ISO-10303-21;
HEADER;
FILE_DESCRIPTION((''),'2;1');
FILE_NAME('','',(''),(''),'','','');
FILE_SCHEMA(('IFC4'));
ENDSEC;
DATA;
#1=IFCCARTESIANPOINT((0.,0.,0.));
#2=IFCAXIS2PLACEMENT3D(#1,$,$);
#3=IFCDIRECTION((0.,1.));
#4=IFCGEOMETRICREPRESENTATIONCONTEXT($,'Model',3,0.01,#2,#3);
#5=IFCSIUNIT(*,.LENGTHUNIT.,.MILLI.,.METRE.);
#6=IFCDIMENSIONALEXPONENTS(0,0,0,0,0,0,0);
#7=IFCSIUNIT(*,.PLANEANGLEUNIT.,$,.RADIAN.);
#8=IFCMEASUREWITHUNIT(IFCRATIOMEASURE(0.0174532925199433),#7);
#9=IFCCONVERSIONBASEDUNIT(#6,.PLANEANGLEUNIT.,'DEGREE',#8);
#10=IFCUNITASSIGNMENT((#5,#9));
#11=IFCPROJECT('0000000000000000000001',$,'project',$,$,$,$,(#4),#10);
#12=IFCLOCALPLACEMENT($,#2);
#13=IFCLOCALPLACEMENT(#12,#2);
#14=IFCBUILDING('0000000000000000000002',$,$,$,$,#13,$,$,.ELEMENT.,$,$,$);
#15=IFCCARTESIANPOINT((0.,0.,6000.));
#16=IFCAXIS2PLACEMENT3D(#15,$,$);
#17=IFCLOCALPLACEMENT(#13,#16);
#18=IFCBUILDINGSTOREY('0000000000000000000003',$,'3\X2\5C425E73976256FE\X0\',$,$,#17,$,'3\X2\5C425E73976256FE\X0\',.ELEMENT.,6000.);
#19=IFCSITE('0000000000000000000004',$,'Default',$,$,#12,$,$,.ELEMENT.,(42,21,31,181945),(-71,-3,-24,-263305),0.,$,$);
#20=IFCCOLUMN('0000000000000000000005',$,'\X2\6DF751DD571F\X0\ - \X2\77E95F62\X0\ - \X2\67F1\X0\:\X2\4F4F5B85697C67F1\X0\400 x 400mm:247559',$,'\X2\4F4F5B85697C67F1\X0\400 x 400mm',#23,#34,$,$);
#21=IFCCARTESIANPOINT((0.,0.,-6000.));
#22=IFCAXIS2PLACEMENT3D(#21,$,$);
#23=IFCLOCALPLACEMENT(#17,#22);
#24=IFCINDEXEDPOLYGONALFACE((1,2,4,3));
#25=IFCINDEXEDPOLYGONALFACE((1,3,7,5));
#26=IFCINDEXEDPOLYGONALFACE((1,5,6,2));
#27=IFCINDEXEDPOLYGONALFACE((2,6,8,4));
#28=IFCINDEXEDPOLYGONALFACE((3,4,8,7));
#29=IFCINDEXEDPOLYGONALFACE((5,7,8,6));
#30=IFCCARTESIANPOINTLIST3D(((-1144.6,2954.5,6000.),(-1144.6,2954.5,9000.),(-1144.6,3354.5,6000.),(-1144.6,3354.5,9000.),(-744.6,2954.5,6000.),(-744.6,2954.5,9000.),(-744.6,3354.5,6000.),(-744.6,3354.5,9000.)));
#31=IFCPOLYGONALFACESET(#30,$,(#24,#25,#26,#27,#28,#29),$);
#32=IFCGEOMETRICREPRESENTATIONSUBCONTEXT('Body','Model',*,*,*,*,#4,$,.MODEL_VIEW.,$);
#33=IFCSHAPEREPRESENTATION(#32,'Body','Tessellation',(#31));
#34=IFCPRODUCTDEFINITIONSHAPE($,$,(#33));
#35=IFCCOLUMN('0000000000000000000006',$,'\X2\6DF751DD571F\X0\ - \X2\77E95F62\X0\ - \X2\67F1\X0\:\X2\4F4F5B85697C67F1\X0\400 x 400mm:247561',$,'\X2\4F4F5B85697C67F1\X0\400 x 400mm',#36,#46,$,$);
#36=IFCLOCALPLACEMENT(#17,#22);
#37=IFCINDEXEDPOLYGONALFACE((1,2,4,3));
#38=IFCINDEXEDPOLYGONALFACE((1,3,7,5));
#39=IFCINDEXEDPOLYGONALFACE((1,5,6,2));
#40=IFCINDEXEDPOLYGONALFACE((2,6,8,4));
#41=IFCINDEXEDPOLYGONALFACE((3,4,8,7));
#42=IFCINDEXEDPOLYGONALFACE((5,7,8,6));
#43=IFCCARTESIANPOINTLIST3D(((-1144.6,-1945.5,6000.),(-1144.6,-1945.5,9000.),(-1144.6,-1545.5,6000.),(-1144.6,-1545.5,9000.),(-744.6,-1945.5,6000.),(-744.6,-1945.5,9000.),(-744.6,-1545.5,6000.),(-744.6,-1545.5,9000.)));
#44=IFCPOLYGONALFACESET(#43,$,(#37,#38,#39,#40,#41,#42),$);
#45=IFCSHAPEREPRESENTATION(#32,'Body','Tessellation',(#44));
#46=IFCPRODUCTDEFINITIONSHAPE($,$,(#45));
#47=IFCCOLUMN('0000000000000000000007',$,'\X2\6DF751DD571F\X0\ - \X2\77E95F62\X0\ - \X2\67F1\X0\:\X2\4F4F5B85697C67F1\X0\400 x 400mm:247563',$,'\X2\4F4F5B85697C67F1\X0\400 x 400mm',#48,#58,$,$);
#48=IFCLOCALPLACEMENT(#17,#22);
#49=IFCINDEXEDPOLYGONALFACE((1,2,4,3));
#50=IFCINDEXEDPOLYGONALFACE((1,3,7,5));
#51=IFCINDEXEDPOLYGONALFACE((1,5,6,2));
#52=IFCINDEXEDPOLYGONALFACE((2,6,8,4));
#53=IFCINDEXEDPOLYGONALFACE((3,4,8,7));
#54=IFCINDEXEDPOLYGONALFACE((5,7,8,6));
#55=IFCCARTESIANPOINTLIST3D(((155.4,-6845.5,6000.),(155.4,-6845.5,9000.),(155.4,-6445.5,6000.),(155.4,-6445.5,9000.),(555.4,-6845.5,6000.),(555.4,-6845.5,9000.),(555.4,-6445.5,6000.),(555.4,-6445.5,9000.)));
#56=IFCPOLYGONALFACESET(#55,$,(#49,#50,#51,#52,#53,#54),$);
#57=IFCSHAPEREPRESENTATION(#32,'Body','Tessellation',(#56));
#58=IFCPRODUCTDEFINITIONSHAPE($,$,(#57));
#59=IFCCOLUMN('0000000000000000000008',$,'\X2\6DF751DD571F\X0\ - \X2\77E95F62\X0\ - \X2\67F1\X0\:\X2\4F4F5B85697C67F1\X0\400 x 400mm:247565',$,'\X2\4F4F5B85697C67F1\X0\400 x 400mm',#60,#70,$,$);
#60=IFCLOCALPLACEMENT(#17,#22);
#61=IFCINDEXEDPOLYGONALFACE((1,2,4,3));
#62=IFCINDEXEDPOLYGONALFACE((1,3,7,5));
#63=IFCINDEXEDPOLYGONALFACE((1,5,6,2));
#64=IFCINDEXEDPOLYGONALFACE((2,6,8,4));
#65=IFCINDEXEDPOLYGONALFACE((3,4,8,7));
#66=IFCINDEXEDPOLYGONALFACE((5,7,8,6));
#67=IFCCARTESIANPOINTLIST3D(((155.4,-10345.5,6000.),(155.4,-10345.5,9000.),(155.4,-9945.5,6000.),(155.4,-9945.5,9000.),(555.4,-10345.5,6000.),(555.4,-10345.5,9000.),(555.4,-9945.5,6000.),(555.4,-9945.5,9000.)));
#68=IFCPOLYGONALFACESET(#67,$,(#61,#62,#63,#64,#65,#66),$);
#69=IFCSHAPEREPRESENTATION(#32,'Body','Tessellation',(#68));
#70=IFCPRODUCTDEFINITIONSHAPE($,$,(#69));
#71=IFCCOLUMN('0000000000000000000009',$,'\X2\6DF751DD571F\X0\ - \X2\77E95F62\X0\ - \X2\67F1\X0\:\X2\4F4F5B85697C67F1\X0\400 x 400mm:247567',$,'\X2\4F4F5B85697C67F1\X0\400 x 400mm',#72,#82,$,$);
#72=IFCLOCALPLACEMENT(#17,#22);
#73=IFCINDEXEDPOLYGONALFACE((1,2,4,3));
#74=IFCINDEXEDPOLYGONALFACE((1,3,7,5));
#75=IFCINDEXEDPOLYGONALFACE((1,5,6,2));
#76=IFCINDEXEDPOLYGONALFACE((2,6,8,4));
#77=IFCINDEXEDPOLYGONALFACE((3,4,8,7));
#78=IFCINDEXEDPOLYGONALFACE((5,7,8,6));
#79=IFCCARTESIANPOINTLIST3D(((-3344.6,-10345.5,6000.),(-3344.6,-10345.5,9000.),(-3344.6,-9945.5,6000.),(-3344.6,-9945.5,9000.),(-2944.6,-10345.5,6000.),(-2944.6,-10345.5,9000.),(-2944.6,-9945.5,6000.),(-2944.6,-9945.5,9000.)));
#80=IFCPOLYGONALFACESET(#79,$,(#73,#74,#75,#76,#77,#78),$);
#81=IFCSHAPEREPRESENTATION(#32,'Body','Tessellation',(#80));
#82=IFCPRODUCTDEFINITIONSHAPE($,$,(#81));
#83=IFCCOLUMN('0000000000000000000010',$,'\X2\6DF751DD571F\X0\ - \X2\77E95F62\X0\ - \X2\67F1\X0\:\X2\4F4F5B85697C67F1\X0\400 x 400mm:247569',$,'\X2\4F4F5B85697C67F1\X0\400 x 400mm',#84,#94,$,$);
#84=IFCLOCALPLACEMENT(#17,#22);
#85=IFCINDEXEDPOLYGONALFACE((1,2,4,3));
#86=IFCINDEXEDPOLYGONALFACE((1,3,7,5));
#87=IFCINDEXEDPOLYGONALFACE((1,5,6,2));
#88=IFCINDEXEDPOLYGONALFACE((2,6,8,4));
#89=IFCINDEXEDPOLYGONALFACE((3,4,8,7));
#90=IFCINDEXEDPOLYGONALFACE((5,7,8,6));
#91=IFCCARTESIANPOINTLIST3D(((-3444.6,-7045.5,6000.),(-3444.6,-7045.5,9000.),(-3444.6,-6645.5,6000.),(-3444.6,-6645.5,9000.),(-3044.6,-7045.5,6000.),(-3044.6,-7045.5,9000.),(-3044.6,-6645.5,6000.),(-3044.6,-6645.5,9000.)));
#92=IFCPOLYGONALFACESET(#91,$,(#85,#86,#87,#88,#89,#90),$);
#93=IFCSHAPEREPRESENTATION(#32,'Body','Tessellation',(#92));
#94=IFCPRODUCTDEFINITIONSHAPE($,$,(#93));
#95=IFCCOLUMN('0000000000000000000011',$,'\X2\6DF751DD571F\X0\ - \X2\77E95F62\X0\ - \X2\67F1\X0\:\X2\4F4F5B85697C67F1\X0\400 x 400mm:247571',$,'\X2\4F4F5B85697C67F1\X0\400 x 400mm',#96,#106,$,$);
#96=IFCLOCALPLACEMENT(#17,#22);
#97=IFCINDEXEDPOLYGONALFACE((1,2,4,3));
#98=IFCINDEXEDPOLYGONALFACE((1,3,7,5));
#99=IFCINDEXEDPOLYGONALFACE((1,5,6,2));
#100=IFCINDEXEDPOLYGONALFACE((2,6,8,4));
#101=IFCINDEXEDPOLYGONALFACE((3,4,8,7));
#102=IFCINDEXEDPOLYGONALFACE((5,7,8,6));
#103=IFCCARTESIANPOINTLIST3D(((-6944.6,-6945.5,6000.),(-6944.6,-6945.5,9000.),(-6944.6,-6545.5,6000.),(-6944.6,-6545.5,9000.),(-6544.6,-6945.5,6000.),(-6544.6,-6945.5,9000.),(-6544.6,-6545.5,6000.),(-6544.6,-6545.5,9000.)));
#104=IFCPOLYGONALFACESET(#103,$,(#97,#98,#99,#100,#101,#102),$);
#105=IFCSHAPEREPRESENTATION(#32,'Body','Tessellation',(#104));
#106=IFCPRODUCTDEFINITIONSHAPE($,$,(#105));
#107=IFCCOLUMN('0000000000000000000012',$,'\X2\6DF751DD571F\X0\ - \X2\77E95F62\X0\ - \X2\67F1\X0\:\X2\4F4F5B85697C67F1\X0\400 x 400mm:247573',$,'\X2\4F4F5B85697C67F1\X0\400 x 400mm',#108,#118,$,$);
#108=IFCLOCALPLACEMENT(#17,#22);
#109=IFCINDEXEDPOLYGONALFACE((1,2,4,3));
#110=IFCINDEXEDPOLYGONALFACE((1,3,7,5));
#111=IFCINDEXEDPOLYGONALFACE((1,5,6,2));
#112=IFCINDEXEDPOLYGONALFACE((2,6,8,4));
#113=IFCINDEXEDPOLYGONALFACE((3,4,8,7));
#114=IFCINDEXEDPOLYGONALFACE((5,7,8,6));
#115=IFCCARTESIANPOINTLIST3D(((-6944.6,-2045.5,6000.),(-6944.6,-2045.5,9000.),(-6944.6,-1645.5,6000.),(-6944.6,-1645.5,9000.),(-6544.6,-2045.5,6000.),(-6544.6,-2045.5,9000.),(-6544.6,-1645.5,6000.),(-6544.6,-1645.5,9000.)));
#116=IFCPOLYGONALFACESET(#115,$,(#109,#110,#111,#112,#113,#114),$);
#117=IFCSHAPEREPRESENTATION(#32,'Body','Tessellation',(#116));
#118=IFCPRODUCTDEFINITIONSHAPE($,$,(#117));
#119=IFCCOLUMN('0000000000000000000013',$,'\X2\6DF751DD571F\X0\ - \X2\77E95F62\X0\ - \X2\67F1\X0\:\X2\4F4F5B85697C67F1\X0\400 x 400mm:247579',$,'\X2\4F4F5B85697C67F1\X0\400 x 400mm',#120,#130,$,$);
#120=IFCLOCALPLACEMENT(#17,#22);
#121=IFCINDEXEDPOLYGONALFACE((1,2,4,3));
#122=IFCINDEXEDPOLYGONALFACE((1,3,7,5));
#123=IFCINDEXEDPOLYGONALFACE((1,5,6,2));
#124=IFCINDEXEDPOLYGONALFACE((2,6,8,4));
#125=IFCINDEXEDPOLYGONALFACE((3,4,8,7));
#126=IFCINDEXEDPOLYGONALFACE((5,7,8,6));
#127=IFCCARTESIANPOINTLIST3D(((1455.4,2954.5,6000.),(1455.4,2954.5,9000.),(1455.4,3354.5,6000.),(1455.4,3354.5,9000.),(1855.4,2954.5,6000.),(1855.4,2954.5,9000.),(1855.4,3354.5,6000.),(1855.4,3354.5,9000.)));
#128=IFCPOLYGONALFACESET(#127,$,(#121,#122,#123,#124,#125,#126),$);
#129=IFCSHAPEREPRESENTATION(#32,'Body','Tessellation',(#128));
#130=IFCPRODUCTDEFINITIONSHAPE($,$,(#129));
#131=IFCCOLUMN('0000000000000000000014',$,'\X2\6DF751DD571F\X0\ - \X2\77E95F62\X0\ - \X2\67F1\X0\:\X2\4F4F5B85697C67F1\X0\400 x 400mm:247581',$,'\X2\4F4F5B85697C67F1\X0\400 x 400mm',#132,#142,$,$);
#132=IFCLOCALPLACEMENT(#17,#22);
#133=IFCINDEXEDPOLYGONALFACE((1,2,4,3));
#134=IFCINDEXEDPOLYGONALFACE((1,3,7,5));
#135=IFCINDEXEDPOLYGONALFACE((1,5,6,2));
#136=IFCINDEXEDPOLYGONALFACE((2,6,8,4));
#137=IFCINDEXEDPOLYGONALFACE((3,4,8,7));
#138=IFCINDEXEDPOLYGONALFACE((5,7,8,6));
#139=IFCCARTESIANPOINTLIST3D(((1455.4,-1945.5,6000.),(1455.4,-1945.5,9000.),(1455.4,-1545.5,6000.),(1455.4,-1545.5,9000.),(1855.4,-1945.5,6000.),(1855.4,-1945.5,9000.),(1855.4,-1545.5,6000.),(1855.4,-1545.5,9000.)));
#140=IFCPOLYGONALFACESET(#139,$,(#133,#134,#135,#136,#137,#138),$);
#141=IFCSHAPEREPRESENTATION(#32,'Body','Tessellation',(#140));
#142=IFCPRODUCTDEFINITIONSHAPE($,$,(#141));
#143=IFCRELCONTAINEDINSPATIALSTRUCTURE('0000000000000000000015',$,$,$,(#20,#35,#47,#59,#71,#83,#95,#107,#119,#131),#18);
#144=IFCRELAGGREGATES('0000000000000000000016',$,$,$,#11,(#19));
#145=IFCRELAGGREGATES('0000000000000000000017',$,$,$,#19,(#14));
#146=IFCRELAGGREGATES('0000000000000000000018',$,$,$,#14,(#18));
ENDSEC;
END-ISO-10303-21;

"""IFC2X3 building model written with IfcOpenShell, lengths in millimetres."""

from ifc_helpers import new_model, entity, si_unit, converted_unit, direction, frame, frame_2d, origin, origin_2d_with_axis, place, context, subcontext, project, spatial, rectangle, extrude, source, transform, mapped, element, save


model = new_model("IFC2X3")

# Units and contexts
model_context = context("Model", 3, precision=0.01, world=origin(), true_north=direction((0.0, 1.0)))
body_context = subcontext(model_context, "Body", "Model", "MODEL_VIEW")
ifc_project = project(units=[si_unit("LENGTHUNIT", "METRE", prefix="MILLI"), converted_unit("PLANEANGLEUNIT", "DEGREE", entity("IfcRatioMeasure", 0.0174532925199433), si_unit("PLANEANGLEUNIT", "RADIAN"), dimensions=[0, 0, 0, 0, 0, 0, 0])], contexts=[model_context])

# Site, building, storey
site_placement = place(None, origin())
site = spatial("IfcSite", under=ifc_project, at=site_placement, Name="Default", CompositionType="ELEMENT", RefLatitude=(42, 21, 31, 181945), RefLongitude=(-71, -3, -24, -263305), RefElevation=0.0)
building_placement = place(site_placement, origin())
building = spatial("IfcBuilding", under=site, at=building_placement, CompositionType="ELEMENT")
storey_placement = place(building_placement, frame((0.0, 0.0, 6000.0)))
storey = spatial("IfcBuildingStorey", under=building, at=storey_placement, Name="3层平面图", LongName="3层平面图", CompositionType="ELEMENT", Elevation=6000.0)

# Columns
shared_shape_1 = source(origin(), body_context, "Body", "SweptSolid", [
    extrude(rectangle(XDim=400.0, YDim=400.0, at=origin_2d_with_axis()), frame((-944.6, 3154.5, 6000.0), z_axis=(0.0, 0.0, 1.0), x_axis=(0.0, -1.0, 0.0)), (0.0, 0.0, 1.0), 3000.0),
])
column_1_placement = place(storey_placement, frame((0.0, 0.0, -6000.0)))
element("IfcColumn", 1, at=column_1_placement, inside=storey, Name="混凝土 - 矩形 - 柱:住宅楼柱400 x 400mm:247559", ObjectType="住宅楼柱400 x 400mm", context=body_context, shape_type="MappedRepresentation", body=[
    mapped(shared_shape_1, transform((0.0, 0.0, 0.0), scale=1.0)),
])
shared_shape_2 = source(origin(), body_context, "Body", "SweptSolid", [
    extrude(rectangle(XDim=400.0, YDim=400.0, at=origin_2d_with_axis()), frame((-944.6, -1745.5, 6000.0), z_axis=(0.0, 0.0, 1.0), x_axis=(0.0, -1.0, 0.0)), (0.0, 0.0, 1.0), 3000.0),
])
column_2_placement = place(storey_placement, frame((0.0, 0.0, -6000.0)))
element("IfcColumn", 2, at=column_2_placement, inside=storey, Name="混凝土 - 矩形 - 柱:住宅楼柱400 x 400mm:247561", ObjectType="住宅楼柱400 x 400mm", context=body_context, shape_type="MappedRepresentation", body=[
    mapped(shared_shape_2, transform((0.0, 0.0, 0.0), scale=1.0)),
])
shared_shape_3 = source(origin(), body_context, "Body", "SweptSolid", [
    extrude(rectangle(XDim=400.0, YDim=400.0, at=frame_2d((0.0, 0.0), x_axis=(1.0, 0.0))), frame((355.4, -6645.5, 6000.0), z_axis=(0.0, 0.0, 1.0), x_axis=(0.0, -1.0, 0.0)), (0.0, 0.0, 1.0), 3000.0),
])
column_3_placement = place(storey_placement, frame((0.0, 0.0, -6000.0)))
element("IfcColumn", 3, at=column_3_placement, inside=storey, Name="混凝土 - 矩形 - 柱:住宅楼柱400 x 400mm:247563", ObjectType="住宅楼柱400 x 400mm", context=body_context, shape_type="MappedRepresentation", body=[
    mapped(shared_shape_3, transform((0.0, 0.0, 0.0), scale=1.0)),
])
shared_shape_4 = source(origin(), body_context, "Body", "SweptSolid", [
    extrude(rectangle(XDim=400.0, YDim=400.0, at=frame_2d((0.0, 0.0), x_axis=(1.0, 0.0))), frame((355.4, -10145.5, 6000.0), z_axis=(0.0, 0.0, 1.0), x_axis=(0.0, -1.0, 0.0)), (0.0, 0.0, 1.0), 3000.0),
])
column_4_placement = place(storey_placement, frame((0.0, 0.0, -6000.0)))
element("IfcColumn", 4, at=column_4_placement, inside=storey, Name="混凝土 - 矩形 - 柱:住宅楼柱400 x 400mm:247565", ObjectType="住宅楼柱400 x 400mm", context=body_context, shape_type="MappedRepresentation", body=[
    mapped(shared_shape_4, transform((0.0, 0.0, 0.0), scale=1.0)),
])
shared_shape_5 = source(origin(), body_context, "Body", "SweptSolid", [
    extrude(rectangle(XDim=400.0, YDim=400.0, at=origin_2d_with_axis()), frame((-3144.6, -10145.5, 6000.0), z_axis=(0.0, 0.0, 1.0), x_axis=(0.0, -1.0, 0.0)), (0.0, 0.0, 1.0), 3000.0),
])
column_5_placement = place(storey_placement, frame((0.0, 0.0, -6000.0)))
element("IfcColumn", 5, at=column_5_placement, inside=storey, Name="混凝土 - 矩形 - 柱:住宅楼柱400 x 400mm:247567", ObjectType="住宅楼柱400 x 400mm", context=body_context, shape_type="MappedRepresentation", body=[
    mapped(shared_shape_5, transform((0.0, 0.0, 0.0), scale=1.0)),
])
shared_shape_6 = source(origin(), body_context, "Body", "SweptSolid", [
    extrude(rectangle(XDim=400.0, YDim=400.0, at=origin_2d_with_axis()), frame((-3244.6, -6845.5, 6000.0), z_axis=(0.0, 0.0, 1.0), x_axis=(0.0, -1.0, 0.0)), (0.0, 0.0, 1.0), 3000.0),
])
column_6_placement = place(storey_placement, frame((0.0, 0.0, -6000.0)))
element("IfcColumn", 6, at=column_6_placement, inside=storey, Name="混凝土 - 矩形 - 柱:住宅楼柱400 x 400mm:247569", ObjectType="住宅楼柱400 x 400mm", context=body_context, shape_type="MappedRepresentation", body=[
    mapped(shared_shape_6, transform((0.0, 0.0, 0.0), scale=1.0)),
])
shared_shape_7 = source(origin(), body_context, "Body", "SweptSolid", [
    extrude(rectangle(XDim=400.0, YDim=400.0, at=origin_2d_with_axis()), frame((-6744.6, -6745.5, 6000.0), z_axis=(0.0, 0.0, 1.0), x_axis=(0.0, -1.0, 0.0)), (0.0, 0.0, 1.0), 3000.0),
])
column_7_placement = place(storey_placement, frame((0.0, 0.0, -6000.0)))
element("IfcColumn", 7, at=column_7_placement, inside=storey, Name="混凝土 - 矩形 - 柱:住宅楼柱400 x 400mm:247571", ObjectType="住宅楼柱400 x 400mm", context=body_context, shape_type="MappedRepresentation", body=[
    mapped(shared_shape_7, transform((0.0, 0.0, 0.0), scale=1.0)),
])
shared_shape_8 = source(origin(), body_context, "Body", "SweptSolid", [
    extrude(rectangle(XDim=400.0, YDim=400.0, at=origin_2d_with_axis()), frame((-6744.6, -1845.5, 6000.0), z_axis=(0.0, 0.0, 1.0), x_axis=(0.0, -1.0, 0.0)), (0.0, 0.0, 1.0), 3000.0),
])
column_8_placement = place(storey_placement, frame((0.0, 0.0, -6000.0)))
element("IfcColumn", 8, at=column_8_placement, inside=storey, Name="混凝土 - 矩形 - 柱:住宅楼柱400 x 400mm:247573", ObjectType="住宅楼柱400 x 400mm", context=body_context, shape_type="MappedRepresentation", body=[
    mapped(shared_shape_8, transform((0.0, 0.0, 0.0), scale=1.0)),
])
shared_shape_9 = source(origin(), body_context, "Body", "SweptSolid", [
    extrude(rectangle(XDim=400.0, YDim=400.0, at=origin_2d_with_axis()), frame((1655.4, 3154.5, 6000.0), z_axis=(0.0, 0.0, 1.0), x_axis=(0.0, -1.0, 0.0)), (0.0, 0.0, 1.0), 3000.0),
])
column_9_placement = place(storey_placement, frame((0.0, 0.0, -6000.0)))
element("IfcColumn", 9, at=column_9_placement, inside=storey, Name="混凝土 - 矩形 - 柱:住宅楼柱400 x 400mm:247579", ObjectType="住宅楼柱400 x 400mm", context=body_context, shape_type="MappedRepresentation", body=[
    mapped(shared_shape_9, transform((0.0, 0.0, 0.0), scale=1.0)),
])
shared_shape_10 = source(origin(), body_context, "Body", "SweptSolid", [
    extrude(rectangle(XDim=400.0, YDim=400.0, at=frame_2d((0.0, 0.0), x_axis=(1.0, 0.0))), frame((1655.4, -1745.5, 6000.0), z_axis=(0.0, 0.0, 1.0), x_axis=(0.0, -1.0, 0.0)), (0.0, 0.0, 1.0), 3000.0),
])
column_10_placement = place(storey_placement, frame((0.0, 0.0, -6000.0)))
element("IfcColumn", 10, at=column_10_placement, inside=storey, Name="混凝土 - 矩形 - 柱:住宅楼柱400 x 400mm:247581", ObjectType="住宅楼柱400 x 400mm", context=body_context, shape_type="MappedRepresentation", body=[
    mapped(shared_shape_10, transform((0.0, 0.0, 0.0), scale=1.0)),
])

save(model, "model.ifc")
